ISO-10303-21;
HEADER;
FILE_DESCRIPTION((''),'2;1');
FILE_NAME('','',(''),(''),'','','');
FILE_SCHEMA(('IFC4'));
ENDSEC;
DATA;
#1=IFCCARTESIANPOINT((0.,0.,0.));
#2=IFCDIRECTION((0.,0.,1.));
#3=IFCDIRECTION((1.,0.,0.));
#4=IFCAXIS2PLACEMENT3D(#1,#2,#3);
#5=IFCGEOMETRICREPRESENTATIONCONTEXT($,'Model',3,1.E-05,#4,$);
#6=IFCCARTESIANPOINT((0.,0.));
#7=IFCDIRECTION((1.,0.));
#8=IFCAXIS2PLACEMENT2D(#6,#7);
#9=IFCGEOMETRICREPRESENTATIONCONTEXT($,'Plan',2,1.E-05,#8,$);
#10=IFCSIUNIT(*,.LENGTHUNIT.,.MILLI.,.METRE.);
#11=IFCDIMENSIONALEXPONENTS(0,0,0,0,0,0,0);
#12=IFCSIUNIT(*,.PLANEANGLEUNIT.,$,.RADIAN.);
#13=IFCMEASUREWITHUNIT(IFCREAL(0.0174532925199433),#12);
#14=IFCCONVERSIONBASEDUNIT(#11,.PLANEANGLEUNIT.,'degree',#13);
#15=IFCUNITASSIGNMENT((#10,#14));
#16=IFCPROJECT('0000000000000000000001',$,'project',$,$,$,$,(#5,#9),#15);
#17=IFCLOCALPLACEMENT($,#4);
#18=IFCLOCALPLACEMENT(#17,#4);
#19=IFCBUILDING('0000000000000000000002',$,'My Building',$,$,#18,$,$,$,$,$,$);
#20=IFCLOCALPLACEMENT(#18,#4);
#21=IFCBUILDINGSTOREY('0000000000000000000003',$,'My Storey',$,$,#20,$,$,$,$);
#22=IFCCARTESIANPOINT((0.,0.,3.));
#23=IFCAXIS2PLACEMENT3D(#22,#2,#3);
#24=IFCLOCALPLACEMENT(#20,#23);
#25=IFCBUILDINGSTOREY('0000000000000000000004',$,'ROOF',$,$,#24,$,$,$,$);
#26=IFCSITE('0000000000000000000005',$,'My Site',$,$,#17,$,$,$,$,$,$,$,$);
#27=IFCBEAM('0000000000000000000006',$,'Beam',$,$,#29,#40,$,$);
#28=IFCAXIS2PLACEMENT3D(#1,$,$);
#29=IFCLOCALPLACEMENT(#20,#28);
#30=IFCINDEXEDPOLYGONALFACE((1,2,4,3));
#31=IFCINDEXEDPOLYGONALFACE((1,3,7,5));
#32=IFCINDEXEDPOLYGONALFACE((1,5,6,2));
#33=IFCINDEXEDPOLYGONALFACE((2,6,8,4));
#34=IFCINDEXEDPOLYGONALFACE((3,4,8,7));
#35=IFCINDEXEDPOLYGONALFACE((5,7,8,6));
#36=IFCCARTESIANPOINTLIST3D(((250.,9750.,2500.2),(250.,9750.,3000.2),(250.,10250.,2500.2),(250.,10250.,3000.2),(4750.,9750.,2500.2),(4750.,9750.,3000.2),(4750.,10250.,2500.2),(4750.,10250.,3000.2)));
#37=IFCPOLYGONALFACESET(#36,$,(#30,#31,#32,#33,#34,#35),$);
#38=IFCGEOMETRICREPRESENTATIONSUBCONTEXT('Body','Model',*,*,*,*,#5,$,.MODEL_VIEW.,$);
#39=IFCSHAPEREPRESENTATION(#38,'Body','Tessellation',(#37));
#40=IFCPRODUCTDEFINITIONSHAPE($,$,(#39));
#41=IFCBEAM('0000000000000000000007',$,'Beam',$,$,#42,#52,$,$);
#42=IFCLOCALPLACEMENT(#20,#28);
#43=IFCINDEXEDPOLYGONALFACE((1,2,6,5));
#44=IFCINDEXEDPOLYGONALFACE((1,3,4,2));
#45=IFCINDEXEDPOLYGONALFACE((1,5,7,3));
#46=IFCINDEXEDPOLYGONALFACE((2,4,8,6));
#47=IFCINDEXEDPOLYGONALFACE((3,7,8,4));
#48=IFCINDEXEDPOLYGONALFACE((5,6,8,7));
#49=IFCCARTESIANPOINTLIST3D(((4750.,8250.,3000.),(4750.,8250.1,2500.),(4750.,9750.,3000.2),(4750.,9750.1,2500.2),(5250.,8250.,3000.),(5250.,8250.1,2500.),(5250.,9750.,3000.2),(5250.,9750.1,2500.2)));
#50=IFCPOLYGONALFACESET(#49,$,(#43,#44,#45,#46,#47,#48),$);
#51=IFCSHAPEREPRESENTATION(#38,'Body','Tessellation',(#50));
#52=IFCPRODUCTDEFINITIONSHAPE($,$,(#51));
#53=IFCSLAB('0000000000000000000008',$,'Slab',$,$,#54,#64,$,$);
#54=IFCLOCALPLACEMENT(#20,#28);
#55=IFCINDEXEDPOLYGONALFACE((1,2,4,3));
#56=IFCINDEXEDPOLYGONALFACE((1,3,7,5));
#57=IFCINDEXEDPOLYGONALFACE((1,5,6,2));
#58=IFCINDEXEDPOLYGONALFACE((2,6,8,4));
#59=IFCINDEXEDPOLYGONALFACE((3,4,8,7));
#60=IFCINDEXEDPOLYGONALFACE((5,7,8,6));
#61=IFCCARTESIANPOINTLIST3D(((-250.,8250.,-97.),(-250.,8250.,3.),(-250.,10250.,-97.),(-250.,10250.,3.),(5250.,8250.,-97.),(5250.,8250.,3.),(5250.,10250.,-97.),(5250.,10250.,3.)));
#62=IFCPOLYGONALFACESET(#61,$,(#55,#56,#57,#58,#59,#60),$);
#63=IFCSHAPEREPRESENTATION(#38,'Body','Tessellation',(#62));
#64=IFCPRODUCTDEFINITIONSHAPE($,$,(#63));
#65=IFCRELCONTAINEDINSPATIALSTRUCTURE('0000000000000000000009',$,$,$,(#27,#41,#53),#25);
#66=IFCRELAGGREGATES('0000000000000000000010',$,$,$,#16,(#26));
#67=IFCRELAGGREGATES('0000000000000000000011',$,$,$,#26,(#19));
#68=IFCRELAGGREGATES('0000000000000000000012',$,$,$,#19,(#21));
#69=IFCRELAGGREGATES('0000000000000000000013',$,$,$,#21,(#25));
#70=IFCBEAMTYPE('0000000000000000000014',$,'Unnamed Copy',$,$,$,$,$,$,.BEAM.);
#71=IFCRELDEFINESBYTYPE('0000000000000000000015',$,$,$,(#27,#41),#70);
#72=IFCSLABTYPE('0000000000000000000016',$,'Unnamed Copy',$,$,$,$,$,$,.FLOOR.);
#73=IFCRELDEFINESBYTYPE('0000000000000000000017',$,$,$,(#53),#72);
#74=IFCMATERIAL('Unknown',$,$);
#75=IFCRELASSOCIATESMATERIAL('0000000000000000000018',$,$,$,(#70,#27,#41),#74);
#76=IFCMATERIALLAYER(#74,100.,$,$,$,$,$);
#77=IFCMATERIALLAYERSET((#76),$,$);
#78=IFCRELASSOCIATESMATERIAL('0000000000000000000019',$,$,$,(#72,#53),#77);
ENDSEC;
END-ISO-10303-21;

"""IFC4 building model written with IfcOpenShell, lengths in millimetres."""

from ifc_helpers import new_model, entity, si_unit, converted_unit, frame, origin_with_axes, origin_2d_with_axis, place, context, subcontext, project, spatial, indexed_curve, rectangle, outline, extrude, material, layer, layer_set, layer_usage, material_profile, profile_set, profile_usage, type_object, element, save


model = new_model("IFC4")

# Units and contexts
model_context = context("Model", 3, precision=1e-05, world=origin_with_axes())
plan_context = context("Plan", 2, precision=1e-05, world=origin_2d_with_axis())
body_context = subcontext(model_context, "Body", "Model", "MODEL_VIEW")
ifc_project = project(units=[si_unit("LENGTHUNIT", "METRE", prefix="MILLI"), converted_unit("PLANEANGLEUNIT", "degree", entity("IfcReal", 0.0174532925199433), si_unit("PLANEANGLEUNIT", "RADIAN"), dimensions=[0, 0, 0, 0, 0, 0, 0])], contexts=[model_context, plan_context])

# Site, building, storeys
site_placement = place(None, origin_with_axes())
site = spatial("IfcSite", under=ifc_project, at=site_placement, Name="My Site")
building_placement = place(site_placement, origin_with_axes())
building = spatial("IfcBuilding", under=site, at=building_placement, Name="My Building")
storey_1_placement = place(building_placement, origin_with_axes())
storey_1 = spatial("IfcBuildingStorey", under=building, at=storey_1_placement, Name="My Storey")
storey_2_placement = place(storey_1_placement, frame((0.0, 0.0, 3.0), z_axis=(0.0, 0.0, 1.0), x_axis=(1.0, 0.0, 0.0)))
storey_2 = spatial("IfcBuildingStorey", under=storey_1, at=storey_2_placement, Name="ROOF")

# Shared definitions
ifc_material = material(Name="Unknown")

# Beams
ifc_material_profile_1 = material_profile(ifc_material, rectangle(XDim=500.0, YDim=500.0))
ifc_profile_set_1 = profile_set([ifc_material_profile_1])
beam_type = type_object("IfcBeamType", Name="Unnamed Copy", PredefinedType="BEAM", material=ifc_profile_set_1)
ifc_profile_usage_1 = profile_usage(ifc_profile_set_1, cardinal=7)
beam_1_placement = place(storey_2_placement, frame((250.0, 10250.0, 2997.2), z_axis=(1.0, -0.000001, 0.000001), x_axis=(0.000001, 1.0, 0.0)))
element("IfcBeam", 1, at=beam_1_placement, inside=storey_2, type_object=beam_type, material=ifc_profile_usage_1, Name="Beam", context=body_context, shape_type="SweptSolid", body=[
    extrude(rectangle(XDim=500.0, YDim=500.0), frame((-250.0, -250.0, 0.0), z_axis=(0.0, 0.0, 1.0), x_axis=(1.0, 0.0, 0.0)), (0.0, 0.0, 1.0), 4500.0),
])
ifc_profile_usage_2 = profile_usage(ifc_profile_set_1, cardinal=7)
beam_2_placement = place(storey_2_placement, frame((5250.0, 9750.0, 2997.2), z_axis=(0.0, -1.0, -0.000133), x_axis=(1.0, 0.0, 0.0)))
element("IfcBeam", 2, at=beam_2_placement, inside=storey_2, type_object=beam_type, material=ifc_profile_usage_2, Name="Beam", context=body_context, shape_type="SweptSolid", body=[
    extrude(rectangle(XDim=500.0, YDim=500.0), frame((-250.0, -250.0, 0.0), z_axis=(0.0, 0.0, 1.0), x_axis=(1.0, 0.0, 0.0)), (0.0, 0.0, 1.0), 1500.0),
])

# Slab
ifc_layer = layer(ifc_material, 100.0)
ifc_layer_set = layer_set([ifc_layer])
ifc_layer_usage = layer_usage(ifc_layer_set, "AXIS3", "POSITIVE", -100.0)
slab_type = type_object("IfcSlabType", Name="Unnamed Copy", PredefinedType="FLOOR", material=ifc_layer_set)
slab_placement = place(storey_2_placement, frame((-250.0, 10250.0, 0.0), z_axis=(0.0, 0.0, 1.0), x_axis=(1.0, 0.0, 0.0)))
element("IfcSlab", 3, at=slab_placement, inside=storey_2, type_object=slab_type, material=ifc_layer_usage, Name="Slab", context=body_context, shape_type="SweptSolid", body=[
    extrude(outline(indexed_curve([(0.0, 0.0), (0.0, -2000.0), (5500.0, -2000.0), (5500.0, 0.0), (0.0, 0.0)])), frame((0.0, 0.0, -100.0), z_axis=(0.0, 0.0, 1.0), x_axis=(1.0, 0.0, 0.0)), (0.0, 0.0, 1.0), 100.0),
])

save(model, "model.ifc")
